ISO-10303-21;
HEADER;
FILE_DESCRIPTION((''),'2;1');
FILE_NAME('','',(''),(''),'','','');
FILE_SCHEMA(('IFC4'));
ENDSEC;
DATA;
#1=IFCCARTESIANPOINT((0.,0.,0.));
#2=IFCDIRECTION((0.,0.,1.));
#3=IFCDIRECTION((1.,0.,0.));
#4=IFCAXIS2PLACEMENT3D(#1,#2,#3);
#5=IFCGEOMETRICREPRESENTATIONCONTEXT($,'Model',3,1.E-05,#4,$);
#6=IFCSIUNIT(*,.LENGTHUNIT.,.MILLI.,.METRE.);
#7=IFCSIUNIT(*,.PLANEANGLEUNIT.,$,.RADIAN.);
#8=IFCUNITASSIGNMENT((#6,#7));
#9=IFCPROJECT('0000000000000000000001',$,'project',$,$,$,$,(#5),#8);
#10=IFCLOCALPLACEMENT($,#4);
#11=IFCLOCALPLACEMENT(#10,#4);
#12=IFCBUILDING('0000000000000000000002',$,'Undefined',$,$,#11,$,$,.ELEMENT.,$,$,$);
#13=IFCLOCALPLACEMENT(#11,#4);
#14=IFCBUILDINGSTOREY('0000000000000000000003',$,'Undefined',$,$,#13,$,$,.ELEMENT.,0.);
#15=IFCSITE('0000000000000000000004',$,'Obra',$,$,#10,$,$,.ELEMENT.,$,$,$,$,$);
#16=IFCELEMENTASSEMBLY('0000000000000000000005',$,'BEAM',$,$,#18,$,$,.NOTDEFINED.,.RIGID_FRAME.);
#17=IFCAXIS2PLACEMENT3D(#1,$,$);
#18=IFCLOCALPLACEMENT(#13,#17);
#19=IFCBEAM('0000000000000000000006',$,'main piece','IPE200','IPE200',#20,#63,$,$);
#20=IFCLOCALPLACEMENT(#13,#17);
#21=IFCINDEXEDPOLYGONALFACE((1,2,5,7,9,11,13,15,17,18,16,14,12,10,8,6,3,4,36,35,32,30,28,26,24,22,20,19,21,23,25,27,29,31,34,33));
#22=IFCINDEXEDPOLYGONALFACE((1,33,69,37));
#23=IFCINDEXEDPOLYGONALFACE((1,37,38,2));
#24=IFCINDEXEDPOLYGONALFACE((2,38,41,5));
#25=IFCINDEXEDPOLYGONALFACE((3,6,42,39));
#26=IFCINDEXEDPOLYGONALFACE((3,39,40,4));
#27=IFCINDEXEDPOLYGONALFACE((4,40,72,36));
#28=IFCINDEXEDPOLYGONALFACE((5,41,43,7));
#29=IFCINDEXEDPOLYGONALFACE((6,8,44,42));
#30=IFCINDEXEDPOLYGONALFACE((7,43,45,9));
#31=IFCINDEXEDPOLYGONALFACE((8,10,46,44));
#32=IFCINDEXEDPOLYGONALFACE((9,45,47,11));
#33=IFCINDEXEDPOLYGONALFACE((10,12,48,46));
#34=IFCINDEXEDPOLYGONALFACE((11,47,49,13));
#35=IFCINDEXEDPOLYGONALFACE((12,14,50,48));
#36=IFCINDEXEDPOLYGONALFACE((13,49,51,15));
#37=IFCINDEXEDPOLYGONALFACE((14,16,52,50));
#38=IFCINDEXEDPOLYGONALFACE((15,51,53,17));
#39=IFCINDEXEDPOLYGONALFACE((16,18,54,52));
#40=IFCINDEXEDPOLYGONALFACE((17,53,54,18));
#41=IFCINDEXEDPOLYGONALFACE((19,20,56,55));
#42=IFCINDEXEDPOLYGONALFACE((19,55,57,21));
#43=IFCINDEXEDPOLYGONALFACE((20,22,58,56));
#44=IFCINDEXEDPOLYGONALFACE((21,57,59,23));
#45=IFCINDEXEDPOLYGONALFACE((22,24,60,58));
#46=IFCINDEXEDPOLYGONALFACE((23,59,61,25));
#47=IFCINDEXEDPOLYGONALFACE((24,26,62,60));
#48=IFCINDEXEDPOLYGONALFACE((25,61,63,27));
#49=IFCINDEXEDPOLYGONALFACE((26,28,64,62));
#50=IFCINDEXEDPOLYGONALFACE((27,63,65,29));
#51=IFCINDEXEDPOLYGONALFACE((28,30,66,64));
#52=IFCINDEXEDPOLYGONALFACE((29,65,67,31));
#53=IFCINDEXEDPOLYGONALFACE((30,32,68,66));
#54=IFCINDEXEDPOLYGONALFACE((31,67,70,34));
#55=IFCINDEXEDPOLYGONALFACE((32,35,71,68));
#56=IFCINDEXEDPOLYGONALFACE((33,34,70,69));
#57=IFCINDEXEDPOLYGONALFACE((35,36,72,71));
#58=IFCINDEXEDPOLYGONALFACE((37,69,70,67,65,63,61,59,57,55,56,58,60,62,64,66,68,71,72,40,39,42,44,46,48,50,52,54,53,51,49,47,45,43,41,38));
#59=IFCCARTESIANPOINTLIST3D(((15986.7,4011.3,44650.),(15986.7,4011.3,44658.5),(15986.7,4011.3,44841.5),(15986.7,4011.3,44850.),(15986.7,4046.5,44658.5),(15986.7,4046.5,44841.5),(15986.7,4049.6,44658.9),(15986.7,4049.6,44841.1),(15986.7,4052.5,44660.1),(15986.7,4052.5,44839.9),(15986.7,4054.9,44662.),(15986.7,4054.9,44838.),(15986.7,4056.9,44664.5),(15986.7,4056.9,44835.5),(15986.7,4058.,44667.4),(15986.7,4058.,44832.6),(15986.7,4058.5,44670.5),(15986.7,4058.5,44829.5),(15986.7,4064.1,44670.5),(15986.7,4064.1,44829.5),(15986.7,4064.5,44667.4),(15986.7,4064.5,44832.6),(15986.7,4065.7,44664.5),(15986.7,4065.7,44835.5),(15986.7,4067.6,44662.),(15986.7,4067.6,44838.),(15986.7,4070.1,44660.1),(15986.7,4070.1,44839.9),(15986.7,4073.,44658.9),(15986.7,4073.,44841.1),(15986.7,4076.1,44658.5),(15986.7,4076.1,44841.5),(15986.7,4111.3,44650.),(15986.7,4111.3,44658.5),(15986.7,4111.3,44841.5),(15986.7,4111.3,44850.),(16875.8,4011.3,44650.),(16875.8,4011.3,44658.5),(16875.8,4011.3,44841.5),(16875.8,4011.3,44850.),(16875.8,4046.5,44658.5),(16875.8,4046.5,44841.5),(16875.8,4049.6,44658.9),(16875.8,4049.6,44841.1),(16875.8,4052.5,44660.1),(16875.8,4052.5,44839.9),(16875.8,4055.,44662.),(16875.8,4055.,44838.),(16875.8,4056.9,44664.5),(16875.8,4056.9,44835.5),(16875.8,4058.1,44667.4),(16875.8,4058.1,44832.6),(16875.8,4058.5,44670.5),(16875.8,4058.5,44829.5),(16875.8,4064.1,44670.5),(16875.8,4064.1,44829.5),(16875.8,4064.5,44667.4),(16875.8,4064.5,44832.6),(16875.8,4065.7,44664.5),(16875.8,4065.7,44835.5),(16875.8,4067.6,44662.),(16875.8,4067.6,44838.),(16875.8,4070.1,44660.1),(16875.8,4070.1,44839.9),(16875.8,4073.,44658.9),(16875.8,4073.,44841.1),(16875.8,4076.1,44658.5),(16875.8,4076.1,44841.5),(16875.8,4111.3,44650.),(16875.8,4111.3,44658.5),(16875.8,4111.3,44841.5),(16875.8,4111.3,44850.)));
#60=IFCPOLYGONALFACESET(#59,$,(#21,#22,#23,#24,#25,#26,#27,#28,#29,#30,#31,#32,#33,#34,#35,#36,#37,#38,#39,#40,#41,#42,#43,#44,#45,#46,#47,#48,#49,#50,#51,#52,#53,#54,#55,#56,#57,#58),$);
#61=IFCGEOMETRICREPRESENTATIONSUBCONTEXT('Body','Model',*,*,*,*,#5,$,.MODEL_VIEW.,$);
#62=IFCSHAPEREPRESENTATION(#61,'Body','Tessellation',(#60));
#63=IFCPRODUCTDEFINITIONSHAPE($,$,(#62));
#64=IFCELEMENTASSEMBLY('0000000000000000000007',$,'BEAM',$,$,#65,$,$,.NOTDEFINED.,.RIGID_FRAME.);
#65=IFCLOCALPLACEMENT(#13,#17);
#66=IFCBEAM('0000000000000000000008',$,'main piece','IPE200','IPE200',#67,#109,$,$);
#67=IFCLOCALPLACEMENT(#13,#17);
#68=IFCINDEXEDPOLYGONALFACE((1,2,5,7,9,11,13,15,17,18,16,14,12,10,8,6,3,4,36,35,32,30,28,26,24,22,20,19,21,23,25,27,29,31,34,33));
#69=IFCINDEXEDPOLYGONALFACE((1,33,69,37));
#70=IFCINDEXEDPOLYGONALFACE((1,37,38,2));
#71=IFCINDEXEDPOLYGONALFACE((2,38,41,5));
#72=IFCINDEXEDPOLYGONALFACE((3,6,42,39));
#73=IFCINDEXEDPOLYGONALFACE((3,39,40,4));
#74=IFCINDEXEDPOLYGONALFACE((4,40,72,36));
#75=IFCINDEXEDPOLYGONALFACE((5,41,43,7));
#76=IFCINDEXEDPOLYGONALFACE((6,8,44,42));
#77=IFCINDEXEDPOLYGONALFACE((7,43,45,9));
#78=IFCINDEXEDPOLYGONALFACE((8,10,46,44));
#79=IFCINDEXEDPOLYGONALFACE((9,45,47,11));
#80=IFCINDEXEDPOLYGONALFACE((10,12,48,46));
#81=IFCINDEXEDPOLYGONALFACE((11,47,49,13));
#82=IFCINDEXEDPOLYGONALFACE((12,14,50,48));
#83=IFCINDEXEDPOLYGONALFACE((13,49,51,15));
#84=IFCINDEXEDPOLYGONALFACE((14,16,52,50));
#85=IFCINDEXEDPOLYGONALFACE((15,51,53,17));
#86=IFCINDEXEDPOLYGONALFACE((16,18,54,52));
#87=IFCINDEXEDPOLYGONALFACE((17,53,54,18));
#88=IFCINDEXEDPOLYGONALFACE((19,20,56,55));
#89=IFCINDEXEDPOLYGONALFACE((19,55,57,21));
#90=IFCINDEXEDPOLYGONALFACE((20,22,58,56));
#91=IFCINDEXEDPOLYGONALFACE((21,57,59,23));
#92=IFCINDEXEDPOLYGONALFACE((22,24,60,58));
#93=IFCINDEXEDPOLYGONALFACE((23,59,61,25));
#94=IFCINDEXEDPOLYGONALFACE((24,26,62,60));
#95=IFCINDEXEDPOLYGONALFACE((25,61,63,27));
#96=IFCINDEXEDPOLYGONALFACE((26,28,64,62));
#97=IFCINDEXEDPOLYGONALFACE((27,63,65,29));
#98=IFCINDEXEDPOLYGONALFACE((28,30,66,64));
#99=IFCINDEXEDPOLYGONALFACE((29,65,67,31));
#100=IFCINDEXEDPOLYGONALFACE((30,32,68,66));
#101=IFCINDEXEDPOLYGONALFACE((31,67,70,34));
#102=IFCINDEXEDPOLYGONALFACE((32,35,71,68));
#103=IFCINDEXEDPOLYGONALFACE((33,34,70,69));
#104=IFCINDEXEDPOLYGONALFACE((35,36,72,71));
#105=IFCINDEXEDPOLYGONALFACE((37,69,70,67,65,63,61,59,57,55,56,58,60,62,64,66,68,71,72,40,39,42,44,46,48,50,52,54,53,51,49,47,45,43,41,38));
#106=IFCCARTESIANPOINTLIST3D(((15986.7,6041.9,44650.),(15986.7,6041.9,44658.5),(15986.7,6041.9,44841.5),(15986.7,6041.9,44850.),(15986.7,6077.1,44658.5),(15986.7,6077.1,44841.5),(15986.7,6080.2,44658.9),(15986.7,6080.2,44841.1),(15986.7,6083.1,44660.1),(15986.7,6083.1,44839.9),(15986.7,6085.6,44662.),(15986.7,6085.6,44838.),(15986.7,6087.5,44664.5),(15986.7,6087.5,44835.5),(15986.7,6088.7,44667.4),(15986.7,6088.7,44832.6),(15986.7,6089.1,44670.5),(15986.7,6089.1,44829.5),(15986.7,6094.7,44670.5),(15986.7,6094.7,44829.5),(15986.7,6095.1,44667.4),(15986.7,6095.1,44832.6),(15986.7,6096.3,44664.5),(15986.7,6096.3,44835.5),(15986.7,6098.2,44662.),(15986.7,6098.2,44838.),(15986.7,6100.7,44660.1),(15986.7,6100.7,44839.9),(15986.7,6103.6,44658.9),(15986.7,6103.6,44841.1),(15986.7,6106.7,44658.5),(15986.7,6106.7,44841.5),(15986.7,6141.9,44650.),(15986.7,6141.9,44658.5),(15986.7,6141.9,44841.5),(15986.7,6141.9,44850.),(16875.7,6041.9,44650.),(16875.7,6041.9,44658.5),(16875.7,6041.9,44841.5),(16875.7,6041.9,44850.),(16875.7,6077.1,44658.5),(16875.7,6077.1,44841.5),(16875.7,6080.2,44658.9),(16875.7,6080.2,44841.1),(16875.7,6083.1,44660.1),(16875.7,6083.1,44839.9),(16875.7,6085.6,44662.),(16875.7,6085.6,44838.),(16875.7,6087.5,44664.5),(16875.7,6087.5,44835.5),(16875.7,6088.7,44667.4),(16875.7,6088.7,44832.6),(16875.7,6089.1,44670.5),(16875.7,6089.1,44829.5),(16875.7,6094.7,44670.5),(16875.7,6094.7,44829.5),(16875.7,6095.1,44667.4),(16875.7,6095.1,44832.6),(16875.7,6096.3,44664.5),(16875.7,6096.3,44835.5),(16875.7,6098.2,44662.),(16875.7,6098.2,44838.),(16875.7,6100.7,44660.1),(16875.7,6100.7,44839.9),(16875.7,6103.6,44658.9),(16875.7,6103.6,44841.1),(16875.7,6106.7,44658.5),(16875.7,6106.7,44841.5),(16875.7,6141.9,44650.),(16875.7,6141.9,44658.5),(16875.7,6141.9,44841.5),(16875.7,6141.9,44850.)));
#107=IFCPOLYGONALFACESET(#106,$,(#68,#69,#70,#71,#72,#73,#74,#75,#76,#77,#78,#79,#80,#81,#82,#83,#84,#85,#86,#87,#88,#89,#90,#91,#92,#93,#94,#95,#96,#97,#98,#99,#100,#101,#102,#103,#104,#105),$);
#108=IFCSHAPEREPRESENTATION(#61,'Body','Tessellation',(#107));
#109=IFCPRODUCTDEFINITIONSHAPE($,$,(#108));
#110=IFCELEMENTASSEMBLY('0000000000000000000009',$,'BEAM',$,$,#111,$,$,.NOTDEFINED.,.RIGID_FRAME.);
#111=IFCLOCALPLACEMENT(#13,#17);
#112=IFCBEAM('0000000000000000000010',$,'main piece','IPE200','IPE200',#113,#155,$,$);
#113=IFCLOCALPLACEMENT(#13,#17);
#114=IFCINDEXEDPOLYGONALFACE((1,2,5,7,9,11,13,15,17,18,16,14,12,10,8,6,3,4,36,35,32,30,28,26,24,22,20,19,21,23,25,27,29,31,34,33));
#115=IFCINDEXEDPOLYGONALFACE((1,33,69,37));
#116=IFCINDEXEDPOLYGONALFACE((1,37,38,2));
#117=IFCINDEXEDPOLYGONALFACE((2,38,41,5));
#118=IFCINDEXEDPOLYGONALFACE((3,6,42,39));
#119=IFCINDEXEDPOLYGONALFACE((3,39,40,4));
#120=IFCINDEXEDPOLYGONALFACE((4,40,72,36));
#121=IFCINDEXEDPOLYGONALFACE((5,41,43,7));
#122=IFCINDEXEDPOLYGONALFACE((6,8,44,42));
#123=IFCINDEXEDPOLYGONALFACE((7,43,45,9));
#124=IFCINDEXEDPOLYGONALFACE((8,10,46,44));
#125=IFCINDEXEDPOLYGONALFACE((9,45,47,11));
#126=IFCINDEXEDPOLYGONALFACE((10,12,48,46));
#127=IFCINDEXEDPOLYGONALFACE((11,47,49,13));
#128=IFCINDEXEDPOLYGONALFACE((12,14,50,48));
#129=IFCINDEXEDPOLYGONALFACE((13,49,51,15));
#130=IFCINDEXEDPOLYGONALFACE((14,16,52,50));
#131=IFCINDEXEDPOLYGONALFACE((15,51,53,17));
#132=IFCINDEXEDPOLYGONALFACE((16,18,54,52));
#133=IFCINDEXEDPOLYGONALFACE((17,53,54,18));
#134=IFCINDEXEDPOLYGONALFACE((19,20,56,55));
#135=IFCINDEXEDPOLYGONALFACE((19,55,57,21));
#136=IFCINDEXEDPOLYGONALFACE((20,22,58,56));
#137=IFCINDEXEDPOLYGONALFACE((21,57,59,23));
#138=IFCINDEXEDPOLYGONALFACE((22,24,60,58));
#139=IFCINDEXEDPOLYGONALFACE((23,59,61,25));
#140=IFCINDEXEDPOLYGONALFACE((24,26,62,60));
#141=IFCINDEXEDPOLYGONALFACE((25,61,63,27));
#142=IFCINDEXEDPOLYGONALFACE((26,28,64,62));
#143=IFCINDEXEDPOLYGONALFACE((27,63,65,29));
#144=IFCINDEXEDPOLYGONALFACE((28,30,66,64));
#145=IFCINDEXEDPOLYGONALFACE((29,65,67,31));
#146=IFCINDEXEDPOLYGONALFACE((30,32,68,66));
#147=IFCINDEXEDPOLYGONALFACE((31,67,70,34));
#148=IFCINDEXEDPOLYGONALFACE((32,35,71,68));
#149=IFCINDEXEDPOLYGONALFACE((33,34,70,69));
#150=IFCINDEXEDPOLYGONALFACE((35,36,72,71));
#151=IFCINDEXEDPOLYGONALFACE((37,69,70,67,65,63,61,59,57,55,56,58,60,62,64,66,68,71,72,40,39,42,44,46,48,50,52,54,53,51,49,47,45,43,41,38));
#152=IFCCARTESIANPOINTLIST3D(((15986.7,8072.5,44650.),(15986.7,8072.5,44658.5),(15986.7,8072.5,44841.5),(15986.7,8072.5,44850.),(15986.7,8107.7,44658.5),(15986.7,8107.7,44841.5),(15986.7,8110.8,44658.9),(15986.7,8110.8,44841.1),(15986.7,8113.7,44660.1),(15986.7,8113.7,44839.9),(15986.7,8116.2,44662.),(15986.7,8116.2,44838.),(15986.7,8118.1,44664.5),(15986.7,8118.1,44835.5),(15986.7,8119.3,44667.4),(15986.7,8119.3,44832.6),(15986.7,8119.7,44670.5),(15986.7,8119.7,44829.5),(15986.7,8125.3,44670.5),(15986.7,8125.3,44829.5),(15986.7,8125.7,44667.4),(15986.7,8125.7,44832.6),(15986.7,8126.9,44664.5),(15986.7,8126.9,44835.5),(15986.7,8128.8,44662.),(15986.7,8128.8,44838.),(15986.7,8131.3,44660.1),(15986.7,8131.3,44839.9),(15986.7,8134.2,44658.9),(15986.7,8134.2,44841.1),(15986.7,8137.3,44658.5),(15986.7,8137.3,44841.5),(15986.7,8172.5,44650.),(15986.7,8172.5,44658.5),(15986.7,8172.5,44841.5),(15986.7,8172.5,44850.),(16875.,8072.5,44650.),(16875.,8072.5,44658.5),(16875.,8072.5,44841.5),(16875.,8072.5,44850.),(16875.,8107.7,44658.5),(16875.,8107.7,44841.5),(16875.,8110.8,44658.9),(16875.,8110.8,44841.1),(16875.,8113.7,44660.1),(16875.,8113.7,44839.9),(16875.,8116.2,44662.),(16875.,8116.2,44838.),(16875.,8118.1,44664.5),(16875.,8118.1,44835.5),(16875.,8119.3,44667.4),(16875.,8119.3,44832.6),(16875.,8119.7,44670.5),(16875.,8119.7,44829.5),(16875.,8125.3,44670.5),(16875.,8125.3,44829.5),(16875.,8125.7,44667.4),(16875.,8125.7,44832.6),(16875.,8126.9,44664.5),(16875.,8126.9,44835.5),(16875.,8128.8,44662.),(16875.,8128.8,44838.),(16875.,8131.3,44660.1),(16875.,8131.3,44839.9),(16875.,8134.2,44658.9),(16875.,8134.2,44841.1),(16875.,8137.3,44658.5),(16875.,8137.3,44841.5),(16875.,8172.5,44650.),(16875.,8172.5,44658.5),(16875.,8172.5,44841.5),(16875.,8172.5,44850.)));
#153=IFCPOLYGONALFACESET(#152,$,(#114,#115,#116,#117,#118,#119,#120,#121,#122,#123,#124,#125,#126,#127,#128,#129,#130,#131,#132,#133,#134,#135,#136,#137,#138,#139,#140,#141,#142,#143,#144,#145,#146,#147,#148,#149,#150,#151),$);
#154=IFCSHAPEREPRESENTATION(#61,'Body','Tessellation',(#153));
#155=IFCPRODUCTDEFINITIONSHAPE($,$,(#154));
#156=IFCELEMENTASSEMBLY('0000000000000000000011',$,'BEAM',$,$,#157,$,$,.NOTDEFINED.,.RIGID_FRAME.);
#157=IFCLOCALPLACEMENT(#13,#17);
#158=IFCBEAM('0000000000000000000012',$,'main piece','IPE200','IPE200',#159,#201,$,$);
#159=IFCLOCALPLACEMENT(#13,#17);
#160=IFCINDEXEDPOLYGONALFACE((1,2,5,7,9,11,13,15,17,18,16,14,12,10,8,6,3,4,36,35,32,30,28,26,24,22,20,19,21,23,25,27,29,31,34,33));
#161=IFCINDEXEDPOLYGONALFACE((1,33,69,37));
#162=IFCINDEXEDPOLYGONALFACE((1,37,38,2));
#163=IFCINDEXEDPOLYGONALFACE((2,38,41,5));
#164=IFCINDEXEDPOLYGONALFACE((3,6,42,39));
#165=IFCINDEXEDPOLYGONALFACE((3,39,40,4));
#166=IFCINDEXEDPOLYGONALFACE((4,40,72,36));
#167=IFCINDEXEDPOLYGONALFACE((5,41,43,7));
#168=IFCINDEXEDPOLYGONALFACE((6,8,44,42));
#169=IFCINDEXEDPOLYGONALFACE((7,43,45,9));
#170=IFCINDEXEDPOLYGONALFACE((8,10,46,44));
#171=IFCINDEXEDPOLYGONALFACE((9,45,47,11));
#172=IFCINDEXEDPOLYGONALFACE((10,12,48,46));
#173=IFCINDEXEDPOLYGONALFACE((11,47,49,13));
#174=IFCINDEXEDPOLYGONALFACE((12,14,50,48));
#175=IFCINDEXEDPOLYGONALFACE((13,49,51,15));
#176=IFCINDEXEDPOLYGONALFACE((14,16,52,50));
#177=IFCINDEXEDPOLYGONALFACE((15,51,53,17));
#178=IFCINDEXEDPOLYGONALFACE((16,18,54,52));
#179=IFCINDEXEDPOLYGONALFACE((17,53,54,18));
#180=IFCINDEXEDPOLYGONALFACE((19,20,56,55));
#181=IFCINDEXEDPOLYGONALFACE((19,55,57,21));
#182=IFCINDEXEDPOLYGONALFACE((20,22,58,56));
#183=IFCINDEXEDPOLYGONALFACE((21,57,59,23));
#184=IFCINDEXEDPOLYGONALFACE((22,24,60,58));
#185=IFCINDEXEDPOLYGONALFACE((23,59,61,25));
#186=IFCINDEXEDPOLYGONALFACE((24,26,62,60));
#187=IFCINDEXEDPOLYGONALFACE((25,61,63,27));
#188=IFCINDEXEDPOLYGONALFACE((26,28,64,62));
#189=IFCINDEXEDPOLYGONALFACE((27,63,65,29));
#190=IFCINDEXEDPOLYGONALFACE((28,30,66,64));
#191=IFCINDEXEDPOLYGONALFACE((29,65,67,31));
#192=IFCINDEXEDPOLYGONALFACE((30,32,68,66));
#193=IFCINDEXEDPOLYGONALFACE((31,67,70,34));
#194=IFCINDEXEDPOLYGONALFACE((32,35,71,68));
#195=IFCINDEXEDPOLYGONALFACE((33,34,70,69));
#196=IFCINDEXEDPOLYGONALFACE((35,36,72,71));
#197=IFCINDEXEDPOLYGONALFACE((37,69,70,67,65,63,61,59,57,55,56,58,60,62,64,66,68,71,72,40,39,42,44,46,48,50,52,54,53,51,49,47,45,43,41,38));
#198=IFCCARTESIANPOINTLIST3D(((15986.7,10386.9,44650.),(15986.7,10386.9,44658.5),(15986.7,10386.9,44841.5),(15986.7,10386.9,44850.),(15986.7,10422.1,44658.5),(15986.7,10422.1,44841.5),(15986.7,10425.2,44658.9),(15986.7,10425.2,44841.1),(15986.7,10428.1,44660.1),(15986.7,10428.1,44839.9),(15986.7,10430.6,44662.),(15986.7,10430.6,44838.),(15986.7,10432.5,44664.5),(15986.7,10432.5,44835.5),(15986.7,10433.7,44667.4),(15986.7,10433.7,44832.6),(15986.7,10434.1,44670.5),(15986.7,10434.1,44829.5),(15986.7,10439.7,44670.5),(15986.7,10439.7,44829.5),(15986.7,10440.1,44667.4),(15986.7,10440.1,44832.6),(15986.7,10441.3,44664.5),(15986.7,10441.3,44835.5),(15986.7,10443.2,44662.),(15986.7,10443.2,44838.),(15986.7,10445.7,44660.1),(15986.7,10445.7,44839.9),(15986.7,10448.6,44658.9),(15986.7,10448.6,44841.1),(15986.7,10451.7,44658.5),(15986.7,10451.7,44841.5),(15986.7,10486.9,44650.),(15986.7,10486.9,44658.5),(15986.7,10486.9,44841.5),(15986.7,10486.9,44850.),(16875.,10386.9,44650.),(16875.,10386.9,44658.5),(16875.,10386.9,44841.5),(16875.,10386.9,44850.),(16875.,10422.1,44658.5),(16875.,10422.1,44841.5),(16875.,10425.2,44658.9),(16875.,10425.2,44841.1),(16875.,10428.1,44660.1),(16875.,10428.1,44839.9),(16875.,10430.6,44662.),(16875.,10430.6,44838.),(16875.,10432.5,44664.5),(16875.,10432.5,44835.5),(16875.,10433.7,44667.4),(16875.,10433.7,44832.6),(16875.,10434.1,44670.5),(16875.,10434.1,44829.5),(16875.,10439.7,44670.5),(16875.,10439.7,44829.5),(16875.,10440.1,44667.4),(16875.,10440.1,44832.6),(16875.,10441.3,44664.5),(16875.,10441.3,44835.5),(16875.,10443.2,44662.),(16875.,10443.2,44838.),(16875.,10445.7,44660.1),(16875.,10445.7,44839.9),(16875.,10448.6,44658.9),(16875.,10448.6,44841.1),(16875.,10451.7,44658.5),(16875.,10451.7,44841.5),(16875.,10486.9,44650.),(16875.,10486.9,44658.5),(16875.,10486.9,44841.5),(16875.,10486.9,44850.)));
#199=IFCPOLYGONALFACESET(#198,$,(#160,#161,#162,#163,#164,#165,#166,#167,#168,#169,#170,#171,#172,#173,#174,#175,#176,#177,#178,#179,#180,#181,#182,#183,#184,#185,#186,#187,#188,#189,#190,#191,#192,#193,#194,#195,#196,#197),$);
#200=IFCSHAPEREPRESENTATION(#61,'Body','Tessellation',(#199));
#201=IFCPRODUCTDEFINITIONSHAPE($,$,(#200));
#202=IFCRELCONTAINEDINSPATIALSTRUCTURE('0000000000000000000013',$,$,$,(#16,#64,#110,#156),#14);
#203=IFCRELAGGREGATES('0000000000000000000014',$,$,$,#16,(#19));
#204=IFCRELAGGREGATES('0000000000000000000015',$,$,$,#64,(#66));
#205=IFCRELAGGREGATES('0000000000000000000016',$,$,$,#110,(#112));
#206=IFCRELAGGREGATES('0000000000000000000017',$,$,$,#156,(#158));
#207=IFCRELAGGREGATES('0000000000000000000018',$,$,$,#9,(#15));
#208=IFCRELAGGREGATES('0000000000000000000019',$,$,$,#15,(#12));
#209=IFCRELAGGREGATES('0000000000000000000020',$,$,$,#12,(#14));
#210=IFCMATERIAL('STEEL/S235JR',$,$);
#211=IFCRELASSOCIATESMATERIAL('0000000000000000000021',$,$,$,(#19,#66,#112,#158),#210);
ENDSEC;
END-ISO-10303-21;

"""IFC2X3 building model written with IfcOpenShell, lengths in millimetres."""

from ifc_helpers import new_model, si_unit, frame, origin_with_axes, origin_2d_with_axis, place, context, subcontext, project, spatial, i_section, extrude, material, element, aggregate, save


model = new_model("IFC2X3")

# Units and contexts
model_context = context("Model", 3, precision=1e-05, world=origin_with_axes())
body_context = subcontext(model_context, "Body", "Model", "MODEL_VIEW")
ifc_project = project(units=[si_unit("LENGTHUNIT", "METRE", prefix="MILLI"), si_unit("PLANEANGLEUNIT", "RADIAN")], contexts=[model_context])

# Site, building, storey
site_placement = place(None, origin_with_axes())
site = spatial("IfcSite", under=ifc_project, at=site_placement, Name="Obra", CompositionType="ELEMENT")
building_placement = place(site_placement, origin_with_axes())
building = spatial("IfcBuilding", under=site, at=building_placement, Name="Undefined", CompositionType="ELEMENT")
storey_placement = place(building_placement, origin_with_axes())
storey = spatial("IfcBuildingStorey", under=building, at=storey_placement, Name="Undefined", CompositionType="ELEMENT", Elevation=0.0)

# Shared definitions
ifc_material = material(Name="STEEL/S235JR")

# Element assemblies, beams
assembly_1_placement = place(storey_placement, origin_with_axes())
assembly_1 = element("IfcElementAssembly", 1, at=assembly_1_placement, inside=storey, Name="BEAM", AssemblyPlace="NOTDEFINED", PredefinedType="RIGID_FRAME")
beam_1_placement = place(assembly_1_placement, frame((16875.8, 4061.3, 44750.0), z_axis=(0.0, 0.0, 1.0), x_axis=(-1.0, -0.000044, 0.0)))
beam_1 = element("IfcBeam", 2, at=beam_1_placement, material=ifc_material, Name="main piece", Description="IPE200", ObjectType="IPE200", context=body_context, shape_type="SweptSolid", body=[
    extrude(i_section(OverallWidth=100.0, OverallDepth=200.0, WebThickness=5.6, FlangeThickness=8.5, FilletRadius=12.0, at=origin_2d_with_axis()), frame((889.1, 0.0, 0.0), z_axis=(-1.0, 0.0, 0.0), x_axis=(0.0, -1.0, 0.0)), (0.0, 0.0, 1.0), 889.1),
])
aggregate(assembly_1, [beam_1])
assembly_2_placement = place(storey_placement, origin_with_axes())
assembly_2 = element("IfcElementAssembly", 3, at=assembly_2_placement, inside=storey, Name="BEAM", AssemblyPlace="NOTDEFINED", PredefinedType="RIGID_FRAME")
beam_2_placement = place(assembly_2_placement, frame((16875.7, 6091.9, 44750.0), z_axis=(0.0, 0.0, 1.0), x_axis=(-1.0, 0.0, 0.0)))
beam_2 = element("IfcBeam", 4, at=beam_2_placement, material=ifc_material, Name="main piece", Description="IPE200", ObjectType="IPE200", context=body_context, shape_type="SweptSolid", body=[
    extrude(i_section(OverallWidth=100.0, OverallDepth=200.0, WebThickness=5.6, FlangeThickness=8.5, FilletRadius=12.0, at=origin_2d_with_axis()), frame((889.0, 0.0, 0.0), z_axis=(-1.0, 0.0, 0.0), x_axis=(0.0, -1.0, 0.0)), (0.0, 0.0, 1.0), 889.0),
])
aggregate(assembly_2, [beam_2])
assembly_3_placement = place(storey_placement, origin_with_axes())
assembly_3 = element("IfcElementAssembly", 5, at=assembly_3_placement, inside=storey, Name="BEAM", AssemblyPlace="NOTDEFINED", PredefinedType="RIGID_FRAME")
beam_3_placement = place(assembly_3_placement, frame((15986.7, 8122.5, 44750.0), z_axis=(0.0, 0.0, 1.0), x_axis=(1.0, 0.0, 0.0)))
beam_3 = element("IfcBeam", 6, at=beam_3_placement, material=ifc_material, Name="main piece", Description="IPE200", ObjectType="IPE200", context=body_context, shape_type="SweptSolid", body=[
    extrude(i_section(OverallWidth=100.0, OverallDepth=200.0, WebThickness=5.6, FlangeThickness=8.5, FilletRadius=12.0, at=origin_2d_with_axis()), frame((888.3, 0.0, 0.0), z_axis=(-1.0, 0.0, 0.0), x_axis=(0.0, -1.0, 0.0)), (0.0, 0.0, 1.0), 888.3),
])
aggregate(assembly_3, [beam_3])
assembly_4_placement = place(storey_placement, origin_with_axes())
assembly_4 = element("IfcElementAssembly", 7, at=assembly_4_placement, inside=storey, Name="BEAM", AssemblyPlace="NOTDEFINED", PredefinedType="RIGID_FRAME")
beam_4_placement = place(assembly_4_placement, frame((16875.0, 10436.9, 44750.0), z_axis=(0.0, 0.0, 1.0), x_axis=(-1.0, 0.0, 0.0)))
beam_4 = element("IfcBeam", 8, at=beam_4_placement, material=ifc_material, Name="main piece", Description="IPE200", ObjectType="IPE200", context=body_context, shape_type="SweptSolid", body=[
    extrude(i_section(OverallWidth=100.0, OverallDepth=200.0, WebThickness=5.6, FlangeThickness=8.5, FilletRadius=12.0, at=origin_2d_with_axis()), frame((888.3, 0.0, 0.0), z_axis=(-1.0, 0.0, 0.0), x_axis=(0.0, -1.0, 0.0)), (0.0, 0.0, 1.0), 888.3),
])
aggregate(assembly_4, [beam_4])

save(model, "model.ifc")
